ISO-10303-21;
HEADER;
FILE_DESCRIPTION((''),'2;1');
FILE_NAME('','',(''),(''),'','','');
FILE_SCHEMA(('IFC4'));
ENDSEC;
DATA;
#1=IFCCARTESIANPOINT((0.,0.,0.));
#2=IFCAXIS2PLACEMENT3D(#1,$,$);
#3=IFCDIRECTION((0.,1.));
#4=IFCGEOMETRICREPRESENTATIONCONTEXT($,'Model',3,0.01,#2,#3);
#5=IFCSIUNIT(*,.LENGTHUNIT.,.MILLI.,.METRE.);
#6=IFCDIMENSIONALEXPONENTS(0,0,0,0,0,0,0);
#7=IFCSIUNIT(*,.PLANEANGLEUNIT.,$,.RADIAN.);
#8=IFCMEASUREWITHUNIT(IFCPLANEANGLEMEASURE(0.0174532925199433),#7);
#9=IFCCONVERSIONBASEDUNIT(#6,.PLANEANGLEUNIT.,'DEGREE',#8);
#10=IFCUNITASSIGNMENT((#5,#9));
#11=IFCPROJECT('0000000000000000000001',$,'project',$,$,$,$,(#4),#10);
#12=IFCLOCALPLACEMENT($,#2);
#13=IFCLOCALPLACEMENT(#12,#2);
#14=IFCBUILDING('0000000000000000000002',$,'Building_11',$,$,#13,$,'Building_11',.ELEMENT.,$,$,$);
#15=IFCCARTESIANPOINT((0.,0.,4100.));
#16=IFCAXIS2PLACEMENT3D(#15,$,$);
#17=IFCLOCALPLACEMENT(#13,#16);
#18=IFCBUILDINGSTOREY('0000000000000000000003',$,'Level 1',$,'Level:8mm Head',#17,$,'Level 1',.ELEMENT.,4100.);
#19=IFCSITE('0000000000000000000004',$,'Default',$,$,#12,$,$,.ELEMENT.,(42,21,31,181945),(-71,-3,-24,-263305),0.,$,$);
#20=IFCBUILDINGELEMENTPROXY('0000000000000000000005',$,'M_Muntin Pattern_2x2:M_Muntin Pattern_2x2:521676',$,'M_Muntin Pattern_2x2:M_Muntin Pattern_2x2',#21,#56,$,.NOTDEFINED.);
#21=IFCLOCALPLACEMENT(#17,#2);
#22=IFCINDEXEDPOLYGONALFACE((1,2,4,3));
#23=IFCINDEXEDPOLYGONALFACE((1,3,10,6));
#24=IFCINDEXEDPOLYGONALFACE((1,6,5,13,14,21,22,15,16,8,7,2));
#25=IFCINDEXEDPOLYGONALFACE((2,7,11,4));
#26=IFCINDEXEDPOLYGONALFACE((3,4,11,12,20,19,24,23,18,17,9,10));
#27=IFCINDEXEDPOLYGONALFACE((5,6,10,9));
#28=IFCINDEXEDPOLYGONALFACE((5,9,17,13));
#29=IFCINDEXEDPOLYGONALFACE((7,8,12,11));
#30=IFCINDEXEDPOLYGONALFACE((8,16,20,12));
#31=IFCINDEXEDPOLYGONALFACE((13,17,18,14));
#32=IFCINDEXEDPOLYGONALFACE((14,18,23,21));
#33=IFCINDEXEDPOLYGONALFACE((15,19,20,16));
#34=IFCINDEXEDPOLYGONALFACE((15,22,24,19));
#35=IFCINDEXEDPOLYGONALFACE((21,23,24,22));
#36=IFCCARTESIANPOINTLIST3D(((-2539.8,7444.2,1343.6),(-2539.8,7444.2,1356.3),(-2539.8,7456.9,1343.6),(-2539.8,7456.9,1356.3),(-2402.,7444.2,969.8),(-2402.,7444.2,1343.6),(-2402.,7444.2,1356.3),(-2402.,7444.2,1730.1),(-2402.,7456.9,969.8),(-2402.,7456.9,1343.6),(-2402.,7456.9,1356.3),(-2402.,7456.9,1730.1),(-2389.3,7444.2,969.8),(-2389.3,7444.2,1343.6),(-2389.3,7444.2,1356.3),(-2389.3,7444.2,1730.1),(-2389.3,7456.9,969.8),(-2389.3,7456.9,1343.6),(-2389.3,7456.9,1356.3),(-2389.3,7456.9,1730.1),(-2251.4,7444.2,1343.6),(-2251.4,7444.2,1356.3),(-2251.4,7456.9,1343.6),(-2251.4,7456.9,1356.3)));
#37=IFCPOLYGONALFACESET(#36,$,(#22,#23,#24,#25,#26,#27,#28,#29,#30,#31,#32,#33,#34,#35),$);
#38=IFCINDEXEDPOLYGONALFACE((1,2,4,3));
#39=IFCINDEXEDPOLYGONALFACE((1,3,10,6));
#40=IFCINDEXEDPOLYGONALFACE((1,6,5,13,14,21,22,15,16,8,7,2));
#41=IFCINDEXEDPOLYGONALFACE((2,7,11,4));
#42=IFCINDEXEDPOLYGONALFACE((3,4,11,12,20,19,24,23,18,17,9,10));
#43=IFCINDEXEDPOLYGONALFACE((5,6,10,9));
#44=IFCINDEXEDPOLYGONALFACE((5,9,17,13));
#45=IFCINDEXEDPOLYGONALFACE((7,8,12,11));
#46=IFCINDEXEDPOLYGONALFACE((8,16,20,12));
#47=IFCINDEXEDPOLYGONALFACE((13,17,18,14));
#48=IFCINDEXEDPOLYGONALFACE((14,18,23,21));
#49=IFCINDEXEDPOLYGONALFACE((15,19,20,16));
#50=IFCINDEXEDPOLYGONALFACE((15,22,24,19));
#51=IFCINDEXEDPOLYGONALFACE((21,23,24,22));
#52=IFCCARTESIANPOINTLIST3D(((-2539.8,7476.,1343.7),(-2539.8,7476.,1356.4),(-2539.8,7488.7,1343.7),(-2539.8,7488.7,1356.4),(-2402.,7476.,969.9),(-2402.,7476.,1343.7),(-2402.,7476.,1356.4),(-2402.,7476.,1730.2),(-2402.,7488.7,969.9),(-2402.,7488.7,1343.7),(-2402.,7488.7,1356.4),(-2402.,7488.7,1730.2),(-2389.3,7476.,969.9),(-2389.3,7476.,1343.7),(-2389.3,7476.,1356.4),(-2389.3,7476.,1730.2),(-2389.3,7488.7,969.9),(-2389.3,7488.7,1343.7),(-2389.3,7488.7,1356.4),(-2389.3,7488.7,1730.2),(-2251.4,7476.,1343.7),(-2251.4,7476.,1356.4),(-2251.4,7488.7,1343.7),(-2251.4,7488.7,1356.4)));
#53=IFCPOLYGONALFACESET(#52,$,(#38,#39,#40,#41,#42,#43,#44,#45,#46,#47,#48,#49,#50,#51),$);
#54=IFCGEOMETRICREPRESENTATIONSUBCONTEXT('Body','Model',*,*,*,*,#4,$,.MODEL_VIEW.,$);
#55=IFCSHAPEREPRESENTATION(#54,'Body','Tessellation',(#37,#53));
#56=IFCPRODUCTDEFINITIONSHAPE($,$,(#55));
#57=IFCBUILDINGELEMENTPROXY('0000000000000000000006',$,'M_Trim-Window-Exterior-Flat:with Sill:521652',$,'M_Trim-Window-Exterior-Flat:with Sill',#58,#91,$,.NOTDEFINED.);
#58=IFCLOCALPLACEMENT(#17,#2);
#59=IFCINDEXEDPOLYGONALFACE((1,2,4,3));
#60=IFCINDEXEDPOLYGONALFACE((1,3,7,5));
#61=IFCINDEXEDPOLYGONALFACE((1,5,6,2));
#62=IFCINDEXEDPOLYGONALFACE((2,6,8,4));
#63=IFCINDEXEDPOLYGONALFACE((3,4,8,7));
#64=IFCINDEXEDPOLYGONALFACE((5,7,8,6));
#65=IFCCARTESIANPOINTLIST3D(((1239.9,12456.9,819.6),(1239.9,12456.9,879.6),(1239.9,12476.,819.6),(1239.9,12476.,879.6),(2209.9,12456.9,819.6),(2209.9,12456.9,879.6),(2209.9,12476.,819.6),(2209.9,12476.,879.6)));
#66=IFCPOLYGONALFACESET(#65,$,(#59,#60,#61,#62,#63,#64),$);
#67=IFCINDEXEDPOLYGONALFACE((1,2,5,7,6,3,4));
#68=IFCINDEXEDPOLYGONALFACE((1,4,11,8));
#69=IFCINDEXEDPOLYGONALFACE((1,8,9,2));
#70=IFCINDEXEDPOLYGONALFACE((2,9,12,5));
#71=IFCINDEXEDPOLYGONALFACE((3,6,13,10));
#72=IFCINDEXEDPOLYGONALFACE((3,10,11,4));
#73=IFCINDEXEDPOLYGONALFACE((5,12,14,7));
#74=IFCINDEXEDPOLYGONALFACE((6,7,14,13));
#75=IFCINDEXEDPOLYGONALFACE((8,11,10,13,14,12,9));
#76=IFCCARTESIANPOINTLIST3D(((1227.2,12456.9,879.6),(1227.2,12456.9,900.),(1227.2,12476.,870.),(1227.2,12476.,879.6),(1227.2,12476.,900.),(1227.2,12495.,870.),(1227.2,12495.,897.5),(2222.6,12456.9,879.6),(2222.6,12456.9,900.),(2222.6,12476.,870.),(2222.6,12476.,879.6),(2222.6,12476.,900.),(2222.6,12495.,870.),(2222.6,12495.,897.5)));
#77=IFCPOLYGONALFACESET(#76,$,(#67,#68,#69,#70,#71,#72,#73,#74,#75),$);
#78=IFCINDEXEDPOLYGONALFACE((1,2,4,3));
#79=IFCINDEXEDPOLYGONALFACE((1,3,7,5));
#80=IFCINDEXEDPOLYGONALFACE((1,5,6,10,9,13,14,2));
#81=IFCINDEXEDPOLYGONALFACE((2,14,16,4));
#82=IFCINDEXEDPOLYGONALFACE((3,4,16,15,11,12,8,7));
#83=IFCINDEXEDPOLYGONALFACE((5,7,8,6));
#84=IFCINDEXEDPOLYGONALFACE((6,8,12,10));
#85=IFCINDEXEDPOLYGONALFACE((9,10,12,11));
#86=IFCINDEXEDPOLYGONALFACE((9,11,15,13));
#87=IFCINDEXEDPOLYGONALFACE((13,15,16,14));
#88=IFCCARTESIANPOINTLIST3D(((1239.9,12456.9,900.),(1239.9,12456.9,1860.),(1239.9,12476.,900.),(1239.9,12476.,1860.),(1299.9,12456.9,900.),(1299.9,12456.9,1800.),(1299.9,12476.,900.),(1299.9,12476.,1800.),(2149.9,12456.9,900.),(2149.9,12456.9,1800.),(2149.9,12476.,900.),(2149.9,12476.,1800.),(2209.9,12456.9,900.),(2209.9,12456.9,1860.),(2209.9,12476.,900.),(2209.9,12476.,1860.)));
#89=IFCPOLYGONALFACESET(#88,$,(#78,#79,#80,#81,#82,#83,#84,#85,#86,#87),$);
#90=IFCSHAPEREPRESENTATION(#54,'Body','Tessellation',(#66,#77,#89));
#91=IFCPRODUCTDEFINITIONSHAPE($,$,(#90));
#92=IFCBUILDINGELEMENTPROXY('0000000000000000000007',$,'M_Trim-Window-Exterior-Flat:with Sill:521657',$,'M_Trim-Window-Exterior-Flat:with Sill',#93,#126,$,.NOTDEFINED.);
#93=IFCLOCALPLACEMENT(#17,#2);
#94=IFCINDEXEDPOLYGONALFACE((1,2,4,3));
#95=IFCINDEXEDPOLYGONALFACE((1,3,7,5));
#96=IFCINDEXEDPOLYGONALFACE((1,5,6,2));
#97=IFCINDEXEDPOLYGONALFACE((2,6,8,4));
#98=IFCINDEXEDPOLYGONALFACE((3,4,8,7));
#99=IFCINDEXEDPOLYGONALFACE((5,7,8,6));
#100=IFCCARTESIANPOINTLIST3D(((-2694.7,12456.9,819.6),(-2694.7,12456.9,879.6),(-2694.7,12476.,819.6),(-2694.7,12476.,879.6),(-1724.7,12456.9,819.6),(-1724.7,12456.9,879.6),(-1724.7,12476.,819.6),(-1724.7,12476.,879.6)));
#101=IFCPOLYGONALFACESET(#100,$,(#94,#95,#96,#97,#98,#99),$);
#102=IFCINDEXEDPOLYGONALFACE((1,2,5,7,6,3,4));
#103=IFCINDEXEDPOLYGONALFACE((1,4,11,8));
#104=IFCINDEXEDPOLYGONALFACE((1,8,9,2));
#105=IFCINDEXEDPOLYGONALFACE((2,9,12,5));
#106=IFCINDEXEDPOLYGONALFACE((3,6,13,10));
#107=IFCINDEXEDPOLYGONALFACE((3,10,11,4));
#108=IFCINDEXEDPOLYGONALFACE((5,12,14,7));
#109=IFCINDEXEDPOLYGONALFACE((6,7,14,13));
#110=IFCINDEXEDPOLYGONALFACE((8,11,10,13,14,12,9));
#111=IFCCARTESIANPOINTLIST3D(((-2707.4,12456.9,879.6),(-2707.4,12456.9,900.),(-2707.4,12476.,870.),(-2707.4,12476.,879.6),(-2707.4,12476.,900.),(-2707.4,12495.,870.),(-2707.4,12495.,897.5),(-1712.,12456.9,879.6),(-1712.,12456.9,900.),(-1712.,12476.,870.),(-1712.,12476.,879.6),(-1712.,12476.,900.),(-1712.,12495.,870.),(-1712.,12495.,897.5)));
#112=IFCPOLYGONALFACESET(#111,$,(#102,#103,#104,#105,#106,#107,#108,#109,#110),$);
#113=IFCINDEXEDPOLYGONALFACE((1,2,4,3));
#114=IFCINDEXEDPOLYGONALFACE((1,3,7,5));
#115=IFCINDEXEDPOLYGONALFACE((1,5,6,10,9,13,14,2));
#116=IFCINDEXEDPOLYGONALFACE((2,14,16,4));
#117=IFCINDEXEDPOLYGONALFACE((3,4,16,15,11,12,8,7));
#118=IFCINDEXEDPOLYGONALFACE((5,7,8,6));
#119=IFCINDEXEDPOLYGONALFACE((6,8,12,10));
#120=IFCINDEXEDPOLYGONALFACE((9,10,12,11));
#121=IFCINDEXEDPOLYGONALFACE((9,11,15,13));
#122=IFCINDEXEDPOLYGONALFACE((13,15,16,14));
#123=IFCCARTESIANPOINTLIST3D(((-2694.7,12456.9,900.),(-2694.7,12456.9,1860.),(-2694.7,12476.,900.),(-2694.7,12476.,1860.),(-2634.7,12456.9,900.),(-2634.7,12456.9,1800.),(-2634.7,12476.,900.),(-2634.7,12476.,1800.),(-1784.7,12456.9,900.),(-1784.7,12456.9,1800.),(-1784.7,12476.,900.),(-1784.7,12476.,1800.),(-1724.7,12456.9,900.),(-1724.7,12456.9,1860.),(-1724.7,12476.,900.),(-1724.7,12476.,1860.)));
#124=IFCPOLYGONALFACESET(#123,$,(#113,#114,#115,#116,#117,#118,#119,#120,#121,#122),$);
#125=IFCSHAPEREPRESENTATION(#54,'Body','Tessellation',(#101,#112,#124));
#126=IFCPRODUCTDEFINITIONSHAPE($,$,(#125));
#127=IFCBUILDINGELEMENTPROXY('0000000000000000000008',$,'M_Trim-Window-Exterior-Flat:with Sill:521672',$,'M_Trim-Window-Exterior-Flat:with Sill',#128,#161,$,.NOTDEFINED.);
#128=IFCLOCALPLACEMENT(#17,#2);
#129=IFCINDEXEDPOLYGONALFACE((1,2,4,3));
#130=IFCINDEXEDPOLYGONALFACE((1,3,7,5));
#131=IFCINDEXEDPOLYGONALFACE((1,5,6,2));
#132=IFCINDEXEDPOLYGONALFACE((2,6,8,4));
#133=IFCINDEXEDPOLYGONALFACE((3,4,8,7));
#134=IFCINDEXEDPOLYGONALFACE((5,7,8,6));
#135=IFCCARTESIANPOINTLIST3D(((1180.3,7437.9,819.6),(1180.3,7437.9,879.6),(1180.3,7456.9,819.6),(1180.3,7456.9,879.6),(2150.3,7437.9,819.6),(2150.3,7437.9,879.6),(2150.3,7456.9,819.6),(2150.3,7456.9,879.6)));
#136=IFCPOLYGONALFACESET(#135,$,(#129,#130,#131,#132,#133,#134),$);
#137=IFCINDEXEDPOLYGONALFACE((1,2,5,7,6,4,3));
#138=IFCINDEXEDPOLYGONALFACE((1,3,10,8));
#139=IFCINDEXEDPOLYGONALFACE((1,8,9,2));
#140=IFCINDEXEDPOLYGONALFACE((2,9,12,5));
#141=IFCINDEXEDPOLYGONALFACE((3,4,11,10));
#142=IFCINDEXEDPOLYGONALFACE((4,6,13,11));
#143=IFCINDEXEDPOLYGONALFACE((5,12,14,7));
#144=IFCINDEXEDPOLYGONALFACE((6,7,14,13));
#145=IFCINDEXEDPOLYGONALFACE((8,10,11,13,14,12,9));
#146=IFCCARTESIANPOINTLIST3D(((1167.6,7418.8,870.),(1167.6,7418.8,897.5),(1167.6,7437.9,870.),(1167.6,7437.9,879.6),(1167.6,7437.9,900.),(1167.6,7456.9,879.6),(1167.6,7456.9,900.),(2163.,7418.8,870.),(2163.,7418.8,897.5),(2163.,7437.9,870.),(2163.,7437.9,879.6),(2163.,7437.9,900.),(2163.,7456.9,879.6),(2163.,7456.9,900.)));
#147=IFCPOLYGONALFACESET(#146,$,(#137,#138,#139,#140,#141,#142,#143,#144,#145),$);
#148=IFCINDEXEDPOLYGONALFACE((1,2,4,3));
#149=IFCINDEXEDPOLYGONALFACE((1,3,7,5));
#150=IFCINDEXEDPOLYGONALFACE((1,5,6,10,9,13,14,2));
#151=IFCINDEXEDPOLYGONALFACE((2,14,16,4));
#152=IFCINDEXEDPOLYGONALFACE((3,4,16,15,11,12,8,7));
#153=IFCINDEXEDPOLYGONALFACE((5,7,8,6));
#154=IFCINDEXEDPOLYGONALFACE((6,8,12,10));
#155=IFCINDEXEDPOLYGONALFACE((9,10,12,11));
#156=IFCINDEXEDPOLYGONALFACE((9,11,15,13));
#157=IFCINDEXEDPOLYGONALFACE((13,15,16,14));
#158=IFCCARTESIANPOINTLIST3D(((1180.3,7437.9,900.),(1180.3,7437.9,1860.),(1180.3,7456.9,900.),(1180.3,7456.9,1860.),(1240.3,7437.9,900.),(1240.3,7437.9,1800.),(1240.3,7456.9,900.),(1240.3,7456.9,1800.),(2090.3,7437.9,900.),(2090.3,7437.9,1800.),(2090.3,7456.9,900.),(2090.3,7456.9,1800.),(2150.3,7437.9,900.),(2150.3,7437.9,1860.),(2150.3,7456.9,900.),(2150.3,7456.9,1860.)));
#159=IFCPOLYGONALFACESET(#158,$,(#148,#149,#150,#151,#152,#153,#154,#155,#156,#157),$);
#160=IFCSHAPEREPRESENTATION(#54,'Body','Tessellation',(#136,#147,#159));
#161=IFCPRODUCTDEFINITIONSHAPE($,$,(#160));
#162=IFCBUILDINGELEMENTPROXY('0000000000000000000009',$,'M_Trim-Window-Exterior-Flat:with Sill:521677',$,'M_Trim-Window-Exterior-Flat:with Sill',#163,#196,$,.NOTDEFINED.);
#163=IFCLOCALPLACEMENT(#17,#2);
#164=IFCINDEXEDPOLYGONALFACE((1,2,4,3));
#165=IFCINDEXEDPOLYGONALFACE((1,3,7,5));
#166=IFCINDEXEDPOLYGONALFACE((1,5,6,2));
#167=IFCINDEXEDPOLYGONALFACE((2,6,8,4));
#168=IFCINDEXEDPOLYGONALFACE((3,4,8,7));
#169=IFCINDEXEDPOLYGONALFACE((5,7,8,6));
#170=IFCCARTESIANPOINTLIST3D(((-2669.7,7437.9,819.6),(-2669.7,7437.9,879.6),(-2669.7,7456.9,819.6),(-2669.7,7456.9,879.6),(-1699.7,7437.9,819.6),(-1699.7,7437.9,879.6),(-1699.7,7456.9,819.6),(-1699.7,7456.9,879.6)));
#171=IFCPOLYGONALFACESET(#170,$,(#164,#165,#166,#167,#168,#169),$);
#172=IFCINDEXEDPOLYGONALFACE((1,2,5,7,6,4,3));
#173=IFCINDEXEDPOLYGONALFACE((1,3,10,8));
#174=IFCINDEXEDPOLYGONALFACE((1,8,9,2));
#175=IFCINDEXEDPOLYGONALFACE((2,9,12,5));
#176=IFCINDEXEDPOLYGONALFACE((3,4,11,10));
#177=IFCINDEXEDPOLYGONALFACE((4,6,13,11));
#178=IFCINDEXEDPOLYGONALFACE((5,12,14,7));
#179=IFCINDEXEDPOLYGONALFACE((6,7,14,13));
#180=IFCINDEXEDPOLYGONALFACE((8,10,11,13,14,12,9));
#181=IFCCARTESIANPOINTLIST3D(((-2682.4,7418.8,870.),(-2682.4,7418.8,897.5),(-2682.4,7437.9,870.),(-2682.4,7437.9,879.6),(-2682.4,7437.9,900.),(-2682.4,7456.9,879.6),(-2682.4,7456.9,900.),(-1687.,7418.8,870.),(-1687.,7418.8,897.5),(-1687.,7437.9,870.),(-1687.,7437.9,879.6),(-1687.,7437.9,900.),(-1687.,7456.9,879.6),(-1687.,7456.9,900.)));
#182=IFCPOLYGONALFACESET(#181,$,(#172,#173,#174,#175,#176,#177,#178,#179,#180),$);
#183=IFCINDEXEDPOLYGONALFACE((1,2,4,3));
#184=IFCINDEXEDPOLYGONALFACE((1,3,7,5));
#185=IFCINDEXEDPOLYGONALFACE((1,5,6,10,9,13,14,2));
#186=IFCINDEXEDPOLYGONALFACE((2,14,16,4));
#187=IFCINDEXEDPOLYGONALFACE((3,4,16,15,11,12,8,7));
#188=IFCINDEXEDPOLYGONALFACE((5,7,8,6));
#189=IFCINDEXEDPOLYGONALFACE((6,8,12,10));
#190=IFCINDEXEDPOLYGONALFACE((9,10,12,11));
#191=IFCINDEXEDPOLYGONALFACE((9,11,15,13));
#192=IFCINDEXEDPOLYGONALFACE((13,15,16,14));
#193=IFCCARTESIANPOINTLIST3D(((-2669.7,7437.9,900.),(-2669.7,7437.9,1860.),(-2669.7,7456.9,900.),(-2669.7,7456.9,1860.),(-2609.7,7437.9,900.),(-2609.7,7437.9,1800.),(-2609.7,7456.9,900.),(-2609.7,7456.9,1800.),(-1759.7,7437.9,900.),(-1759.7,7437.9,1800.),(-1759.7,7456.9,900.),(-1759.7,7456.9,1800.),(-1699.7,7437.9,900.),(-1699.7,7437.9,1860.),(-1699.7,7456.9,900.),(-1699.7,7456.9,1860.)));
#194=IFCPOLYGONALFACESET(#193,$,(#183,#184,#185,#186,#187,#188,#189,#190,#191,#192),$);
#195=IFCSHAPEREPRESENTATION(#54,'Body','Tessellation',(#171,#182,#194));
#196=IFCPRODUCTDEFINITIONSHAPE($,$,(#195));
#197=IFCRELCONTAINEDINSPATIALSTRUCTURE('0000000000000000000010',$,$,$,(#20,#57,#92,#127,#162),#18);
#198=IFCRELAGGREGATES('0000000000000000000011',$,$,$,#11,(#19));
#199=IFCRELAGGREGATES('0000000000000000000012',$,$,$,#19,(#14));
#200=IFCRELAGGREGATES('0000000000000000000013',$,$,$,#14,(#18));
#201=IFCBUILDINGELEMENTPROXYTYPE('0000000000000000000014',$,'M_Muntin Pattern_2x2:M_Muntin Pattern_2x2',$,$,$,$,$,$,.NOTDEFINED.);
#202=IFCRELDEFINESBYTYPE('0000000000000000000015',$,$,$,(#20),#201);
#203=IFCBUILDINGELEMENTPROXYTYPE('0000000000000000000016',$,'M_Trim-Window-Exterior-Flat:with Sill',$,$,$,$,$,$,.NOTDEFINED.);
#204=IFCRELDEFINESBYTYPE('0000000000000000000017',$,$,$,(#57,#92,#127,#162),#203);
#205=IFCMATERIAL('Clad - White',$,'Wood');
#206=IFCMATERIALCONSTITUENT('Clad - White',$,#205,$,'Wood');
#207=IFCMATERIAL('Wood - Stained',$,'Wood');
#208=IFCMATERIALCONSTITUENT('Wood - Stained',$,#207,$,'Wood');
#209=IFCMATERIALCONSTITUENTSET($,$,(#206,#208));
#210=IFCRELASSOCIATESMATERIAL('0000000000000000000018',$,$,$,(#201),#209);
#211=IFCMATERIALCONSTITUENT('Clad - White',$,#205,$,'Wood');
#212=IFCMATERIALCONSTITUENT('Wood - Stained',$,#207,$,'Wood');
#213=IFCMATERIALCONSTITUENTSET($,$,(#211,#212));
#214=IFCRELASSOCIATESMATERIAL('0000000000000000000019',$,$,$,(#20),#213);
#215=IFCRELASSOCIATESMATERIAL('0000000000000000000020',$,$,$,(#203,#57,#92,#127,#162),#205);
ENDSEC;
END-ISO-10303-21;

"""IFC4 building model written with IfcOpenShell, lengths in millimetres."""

from ifc_helpers import new_model, entity, si_unit, converted_unit, direction, frame, origin, place, context, subcontext, project, spatial, indexed_curve, outline, extrude, source, transform, mapped, material, constituent, constituent_set, type_object, type_shapes, element, save


model = new_model("IFC4")

# Units and contexts
model_context = context("Model", 3, precision=0.01, world=origin(), true_north=direction((0.0, 1.0)))
body_context = subcontext(model_context, "Body", "Model", "MODEL_VIEW")
ifc_project = project(units=[si_unit("LENGTHUNIT", "METRE", prefix="MILLI"), converted_unit("PLANEANGLEUNIT", "DEGREE", entity("IfcPlaneAngleMeasure", 0.0174532925199433), si_unit("PLANEANGLEUNIT", "RADIAN"), dimensions=[0, 0, 0, 0, 0, 0, 0])], contexts=[model_context])

# Site, building, storey
site_placement = place(None, origin())
site = spatial("IfcSite", under=ifc_project, at=site_placement, Name="Default", CompositionType="ELEMENT", RefLatitude=(42, 21, 31, 181945), RefLongitude=(-71, -3, -24, -263305), RefElevation=0.0)
building_placement = place(site_placement, origin())
building = spatial("IfcBuilding", under=site, at=building_placement, Name="Building_11", LongName="Building_11", CompositionType="ELEMENT")
storey_placement = place(building_placement, frame((0.0, 0.0, 4100.0)))
storey = spatial("IfcBuildingStorey", under=building, at=storey_placement, Name="Level 1", ObjectType="Level:8mm Head", LongName="Level 1", CompositionType="ELEMENT", Elevation=4100.0)

# Building element proxies
ifc_material_1 = material(Name="Clad - White", Category="Wood")
ifc_material_2 = material(Name="Wood - Stained", Category="Wood")
ifc_constituent_1 = constituent(ifc_material_1, Name="Clad - White", Category="Wood")
ifc_constituent_2 = constituent(ifc_material_2, Name="Wood - Stained", Category="Wood")
ifc_constituent_set_1 = constituent_set(constituents=[ifc_constituent_1, ifc_constituent_2])
building_element_proxy_type_1 = type_object("IfcBuildingElementProxyType", Name="M_Muntin Pattern_2x2:M_Muntin Pattern_2x2", PredefinedType="NOTDEFINED", material=ifc_constituent_set_1)
shared_shape_1 = source(origin(), body_context, "Body", "SweptSolid", [
    extrude(outline(indexed_curve([(6.4, -6.4), (380.1, -6.4), (380.1, 6.3), (6.4, 6.3), (6.4, 144.2), (-6.3, 144.2), (-6.3, 6.3), (-380.2, 6.3), (-380.2, -6.4), (-6.3, -6.4), (-6.3, -144.2), (6.4, -144.2), (6.4, -6.4)], self_intersect=False)), frame((0.0, -22.2, 380.1), z_axis=(0.0, 1.0, 0.0), x_axis=(0.0, 0.0, 1.0)), (0.0, 0.0, 1.0), 12.7),
    extrude(outline(indexed_curve([(6.4, -6.4), (380.2, -6.4), (380.2, 6.3), (6.4, 6.3), (6.4, 144.2), (-6.3, 144.2), (-6.3, 6.3), (-380.2, 6.3), (-380.2, -6.4), (-6.3, -6.4), (-6.3, -144.2), (6.4, -144.2), (6.4, -6.4)], self_intersect=False)), frame((0.0, 9.5, 380.2), z_axis=(0.0, 1.0, 0.0), x_axis=(0.0, 0.0, 1.0)), (0.0, 0.0, 1.0), 12.7),
])
type_shapes(building_element_proxy_type_1, [shared_shape_1])
ifc_constituent_3 = constituent(ifc_material_1, Name="Clad - White", Category="Wood")
ifc_constituent_4 = constituent(ifc_material_2, Name="Wood - Stained", Category="Wood")
ifc_constituent_set_2 = constituent_set(constituents=[ifc_constituent_3, ifc_constituent_4])
proxy_1_placement = place(storey_placement, frame((-2395.6, 7466.4, 969.9)))
element("IfcBuildingElementProxy", 1, at=proxy_1_placement, inside=storey, type_object=building_element_proxy_type_1, material=ifc_constituent_set_2, Name="M_Muntin Pattern_2x2:M_Muntin Pattern_2x2:521676", ObjectType="M_Muntin Pattern_2x2:M_Muntin Pattern_2x2", PredefinedType="NOTDEFINED", context=body_context, shape_type="MappedRepresentation", body=[
    mapped(shared_shape_1, transform((0.0, 0.0, 0.0), scale=1.0)),
])
building_element_proxy_type_2 = type_object("IfcBuildingElementProxyType", Name="M_Trim-Window-Exterior-Flat:with Sill", PredefinedType="NOTDEFINED", material=ifc_material_1)
shared_shape_2 = source(origin(), body_context, "Body", "SweptSolid", [
    extrude(outline(indexed_curve([(-485.0, -30.0), (485.0, -30.0), (485.0, 30.0), (-485.0, 30.0), (-485.0, -30.0)], self_intersect=False)), frame((0.0, -950.4, 0.0), z_axis=(0.0, 0.0, 1.0), x_axis=(-1.0, 0.0, 0.0)), (0.0, 0.0, 1.0), 19.1),
    extrude(outline(indexed_curve([(-19.0, -15.2), (0.0, -15.2), (0.0, -5.7), (19.0, -5.7), (19.0, 14.8), (0.0, 14.8), (-19.0, 12.3), (-19.0, -15.2)], self_intersect=False)), frame((-497.7, -914.8, 19.0), z_axis=(1.0, 0.0, 0.0), x_axis=(0.0, 0.0, -1.0)), (0.0, 0.0, 1.0), 995.4),
    extrude(outline(indexed_curve([(-495.0, -485.0), (465.0, -485.0), (465.0, -425.0), (-435.0, -425.0), (-435.0, 425.0), (465.0, 425.0), (465.0, 485.0), (-495.0, 485.0), (-495.0, -485.0)], self_intersect=False)), frame((0.0, -435.0, 0.0), z_axis=(0.0, 0.0, 1.0), x_axis=(0.0, -1.0, 0.0)), (0.0, 0.0, 1.0), 19.1),
])
type_shapes(building_element_proxy_type_2, [shared_shape_2])
for number, where, z_axis, x_axis, name in (
    (2, (1724.9, 12456.9, 1800.0), (0.0, 1.0, 0.0), (-1.0, 0.0, 0.0), "M_Trim-Window-Exterior-Flat:with Sill:521652"),
    (3, (-2209.7, 12456.9, 1800.0), (0.0, 1.0, 0.0), (-1.0, 0.0, 0.0), "M_Trim-Window-Exterior-Flat:with Sill:521657"),
    (4, (1665.3, 7456.9, 1800.0), (0.0, -1.0, 0.0), (1.0, 0.0, 0.0), "M_Trim-Window-Exterior-Flat:with Sill:521672"),
    (5, (-2184.7, 7456.9, 1800.0), (0.0, -1.0, 0.0), (1.0, 0.0, 0.0), "M_Trim-Window-Exterior-Flat:with Sill:521677"),
):
    element("IfcBuildingElementProxy", number, at=place(storey_placement, frame(where, z_axis=z_axis, x_axis=x_axis)), inside=storey, type_object=building_element_proxy_type_2, material=ifc_material_1, Name=name, ObjectType="M_Trim-Window-Exterior-Flat:with Sill", PredefinedType="NOTDEFINED", context=body_context, shape_type="MappedRepresentation", body=[
        mapped(shared_shape_2, transform((0.0, 0.0, 0.0), scale=1.0)),
    ])

save(model, "model.ifc")
